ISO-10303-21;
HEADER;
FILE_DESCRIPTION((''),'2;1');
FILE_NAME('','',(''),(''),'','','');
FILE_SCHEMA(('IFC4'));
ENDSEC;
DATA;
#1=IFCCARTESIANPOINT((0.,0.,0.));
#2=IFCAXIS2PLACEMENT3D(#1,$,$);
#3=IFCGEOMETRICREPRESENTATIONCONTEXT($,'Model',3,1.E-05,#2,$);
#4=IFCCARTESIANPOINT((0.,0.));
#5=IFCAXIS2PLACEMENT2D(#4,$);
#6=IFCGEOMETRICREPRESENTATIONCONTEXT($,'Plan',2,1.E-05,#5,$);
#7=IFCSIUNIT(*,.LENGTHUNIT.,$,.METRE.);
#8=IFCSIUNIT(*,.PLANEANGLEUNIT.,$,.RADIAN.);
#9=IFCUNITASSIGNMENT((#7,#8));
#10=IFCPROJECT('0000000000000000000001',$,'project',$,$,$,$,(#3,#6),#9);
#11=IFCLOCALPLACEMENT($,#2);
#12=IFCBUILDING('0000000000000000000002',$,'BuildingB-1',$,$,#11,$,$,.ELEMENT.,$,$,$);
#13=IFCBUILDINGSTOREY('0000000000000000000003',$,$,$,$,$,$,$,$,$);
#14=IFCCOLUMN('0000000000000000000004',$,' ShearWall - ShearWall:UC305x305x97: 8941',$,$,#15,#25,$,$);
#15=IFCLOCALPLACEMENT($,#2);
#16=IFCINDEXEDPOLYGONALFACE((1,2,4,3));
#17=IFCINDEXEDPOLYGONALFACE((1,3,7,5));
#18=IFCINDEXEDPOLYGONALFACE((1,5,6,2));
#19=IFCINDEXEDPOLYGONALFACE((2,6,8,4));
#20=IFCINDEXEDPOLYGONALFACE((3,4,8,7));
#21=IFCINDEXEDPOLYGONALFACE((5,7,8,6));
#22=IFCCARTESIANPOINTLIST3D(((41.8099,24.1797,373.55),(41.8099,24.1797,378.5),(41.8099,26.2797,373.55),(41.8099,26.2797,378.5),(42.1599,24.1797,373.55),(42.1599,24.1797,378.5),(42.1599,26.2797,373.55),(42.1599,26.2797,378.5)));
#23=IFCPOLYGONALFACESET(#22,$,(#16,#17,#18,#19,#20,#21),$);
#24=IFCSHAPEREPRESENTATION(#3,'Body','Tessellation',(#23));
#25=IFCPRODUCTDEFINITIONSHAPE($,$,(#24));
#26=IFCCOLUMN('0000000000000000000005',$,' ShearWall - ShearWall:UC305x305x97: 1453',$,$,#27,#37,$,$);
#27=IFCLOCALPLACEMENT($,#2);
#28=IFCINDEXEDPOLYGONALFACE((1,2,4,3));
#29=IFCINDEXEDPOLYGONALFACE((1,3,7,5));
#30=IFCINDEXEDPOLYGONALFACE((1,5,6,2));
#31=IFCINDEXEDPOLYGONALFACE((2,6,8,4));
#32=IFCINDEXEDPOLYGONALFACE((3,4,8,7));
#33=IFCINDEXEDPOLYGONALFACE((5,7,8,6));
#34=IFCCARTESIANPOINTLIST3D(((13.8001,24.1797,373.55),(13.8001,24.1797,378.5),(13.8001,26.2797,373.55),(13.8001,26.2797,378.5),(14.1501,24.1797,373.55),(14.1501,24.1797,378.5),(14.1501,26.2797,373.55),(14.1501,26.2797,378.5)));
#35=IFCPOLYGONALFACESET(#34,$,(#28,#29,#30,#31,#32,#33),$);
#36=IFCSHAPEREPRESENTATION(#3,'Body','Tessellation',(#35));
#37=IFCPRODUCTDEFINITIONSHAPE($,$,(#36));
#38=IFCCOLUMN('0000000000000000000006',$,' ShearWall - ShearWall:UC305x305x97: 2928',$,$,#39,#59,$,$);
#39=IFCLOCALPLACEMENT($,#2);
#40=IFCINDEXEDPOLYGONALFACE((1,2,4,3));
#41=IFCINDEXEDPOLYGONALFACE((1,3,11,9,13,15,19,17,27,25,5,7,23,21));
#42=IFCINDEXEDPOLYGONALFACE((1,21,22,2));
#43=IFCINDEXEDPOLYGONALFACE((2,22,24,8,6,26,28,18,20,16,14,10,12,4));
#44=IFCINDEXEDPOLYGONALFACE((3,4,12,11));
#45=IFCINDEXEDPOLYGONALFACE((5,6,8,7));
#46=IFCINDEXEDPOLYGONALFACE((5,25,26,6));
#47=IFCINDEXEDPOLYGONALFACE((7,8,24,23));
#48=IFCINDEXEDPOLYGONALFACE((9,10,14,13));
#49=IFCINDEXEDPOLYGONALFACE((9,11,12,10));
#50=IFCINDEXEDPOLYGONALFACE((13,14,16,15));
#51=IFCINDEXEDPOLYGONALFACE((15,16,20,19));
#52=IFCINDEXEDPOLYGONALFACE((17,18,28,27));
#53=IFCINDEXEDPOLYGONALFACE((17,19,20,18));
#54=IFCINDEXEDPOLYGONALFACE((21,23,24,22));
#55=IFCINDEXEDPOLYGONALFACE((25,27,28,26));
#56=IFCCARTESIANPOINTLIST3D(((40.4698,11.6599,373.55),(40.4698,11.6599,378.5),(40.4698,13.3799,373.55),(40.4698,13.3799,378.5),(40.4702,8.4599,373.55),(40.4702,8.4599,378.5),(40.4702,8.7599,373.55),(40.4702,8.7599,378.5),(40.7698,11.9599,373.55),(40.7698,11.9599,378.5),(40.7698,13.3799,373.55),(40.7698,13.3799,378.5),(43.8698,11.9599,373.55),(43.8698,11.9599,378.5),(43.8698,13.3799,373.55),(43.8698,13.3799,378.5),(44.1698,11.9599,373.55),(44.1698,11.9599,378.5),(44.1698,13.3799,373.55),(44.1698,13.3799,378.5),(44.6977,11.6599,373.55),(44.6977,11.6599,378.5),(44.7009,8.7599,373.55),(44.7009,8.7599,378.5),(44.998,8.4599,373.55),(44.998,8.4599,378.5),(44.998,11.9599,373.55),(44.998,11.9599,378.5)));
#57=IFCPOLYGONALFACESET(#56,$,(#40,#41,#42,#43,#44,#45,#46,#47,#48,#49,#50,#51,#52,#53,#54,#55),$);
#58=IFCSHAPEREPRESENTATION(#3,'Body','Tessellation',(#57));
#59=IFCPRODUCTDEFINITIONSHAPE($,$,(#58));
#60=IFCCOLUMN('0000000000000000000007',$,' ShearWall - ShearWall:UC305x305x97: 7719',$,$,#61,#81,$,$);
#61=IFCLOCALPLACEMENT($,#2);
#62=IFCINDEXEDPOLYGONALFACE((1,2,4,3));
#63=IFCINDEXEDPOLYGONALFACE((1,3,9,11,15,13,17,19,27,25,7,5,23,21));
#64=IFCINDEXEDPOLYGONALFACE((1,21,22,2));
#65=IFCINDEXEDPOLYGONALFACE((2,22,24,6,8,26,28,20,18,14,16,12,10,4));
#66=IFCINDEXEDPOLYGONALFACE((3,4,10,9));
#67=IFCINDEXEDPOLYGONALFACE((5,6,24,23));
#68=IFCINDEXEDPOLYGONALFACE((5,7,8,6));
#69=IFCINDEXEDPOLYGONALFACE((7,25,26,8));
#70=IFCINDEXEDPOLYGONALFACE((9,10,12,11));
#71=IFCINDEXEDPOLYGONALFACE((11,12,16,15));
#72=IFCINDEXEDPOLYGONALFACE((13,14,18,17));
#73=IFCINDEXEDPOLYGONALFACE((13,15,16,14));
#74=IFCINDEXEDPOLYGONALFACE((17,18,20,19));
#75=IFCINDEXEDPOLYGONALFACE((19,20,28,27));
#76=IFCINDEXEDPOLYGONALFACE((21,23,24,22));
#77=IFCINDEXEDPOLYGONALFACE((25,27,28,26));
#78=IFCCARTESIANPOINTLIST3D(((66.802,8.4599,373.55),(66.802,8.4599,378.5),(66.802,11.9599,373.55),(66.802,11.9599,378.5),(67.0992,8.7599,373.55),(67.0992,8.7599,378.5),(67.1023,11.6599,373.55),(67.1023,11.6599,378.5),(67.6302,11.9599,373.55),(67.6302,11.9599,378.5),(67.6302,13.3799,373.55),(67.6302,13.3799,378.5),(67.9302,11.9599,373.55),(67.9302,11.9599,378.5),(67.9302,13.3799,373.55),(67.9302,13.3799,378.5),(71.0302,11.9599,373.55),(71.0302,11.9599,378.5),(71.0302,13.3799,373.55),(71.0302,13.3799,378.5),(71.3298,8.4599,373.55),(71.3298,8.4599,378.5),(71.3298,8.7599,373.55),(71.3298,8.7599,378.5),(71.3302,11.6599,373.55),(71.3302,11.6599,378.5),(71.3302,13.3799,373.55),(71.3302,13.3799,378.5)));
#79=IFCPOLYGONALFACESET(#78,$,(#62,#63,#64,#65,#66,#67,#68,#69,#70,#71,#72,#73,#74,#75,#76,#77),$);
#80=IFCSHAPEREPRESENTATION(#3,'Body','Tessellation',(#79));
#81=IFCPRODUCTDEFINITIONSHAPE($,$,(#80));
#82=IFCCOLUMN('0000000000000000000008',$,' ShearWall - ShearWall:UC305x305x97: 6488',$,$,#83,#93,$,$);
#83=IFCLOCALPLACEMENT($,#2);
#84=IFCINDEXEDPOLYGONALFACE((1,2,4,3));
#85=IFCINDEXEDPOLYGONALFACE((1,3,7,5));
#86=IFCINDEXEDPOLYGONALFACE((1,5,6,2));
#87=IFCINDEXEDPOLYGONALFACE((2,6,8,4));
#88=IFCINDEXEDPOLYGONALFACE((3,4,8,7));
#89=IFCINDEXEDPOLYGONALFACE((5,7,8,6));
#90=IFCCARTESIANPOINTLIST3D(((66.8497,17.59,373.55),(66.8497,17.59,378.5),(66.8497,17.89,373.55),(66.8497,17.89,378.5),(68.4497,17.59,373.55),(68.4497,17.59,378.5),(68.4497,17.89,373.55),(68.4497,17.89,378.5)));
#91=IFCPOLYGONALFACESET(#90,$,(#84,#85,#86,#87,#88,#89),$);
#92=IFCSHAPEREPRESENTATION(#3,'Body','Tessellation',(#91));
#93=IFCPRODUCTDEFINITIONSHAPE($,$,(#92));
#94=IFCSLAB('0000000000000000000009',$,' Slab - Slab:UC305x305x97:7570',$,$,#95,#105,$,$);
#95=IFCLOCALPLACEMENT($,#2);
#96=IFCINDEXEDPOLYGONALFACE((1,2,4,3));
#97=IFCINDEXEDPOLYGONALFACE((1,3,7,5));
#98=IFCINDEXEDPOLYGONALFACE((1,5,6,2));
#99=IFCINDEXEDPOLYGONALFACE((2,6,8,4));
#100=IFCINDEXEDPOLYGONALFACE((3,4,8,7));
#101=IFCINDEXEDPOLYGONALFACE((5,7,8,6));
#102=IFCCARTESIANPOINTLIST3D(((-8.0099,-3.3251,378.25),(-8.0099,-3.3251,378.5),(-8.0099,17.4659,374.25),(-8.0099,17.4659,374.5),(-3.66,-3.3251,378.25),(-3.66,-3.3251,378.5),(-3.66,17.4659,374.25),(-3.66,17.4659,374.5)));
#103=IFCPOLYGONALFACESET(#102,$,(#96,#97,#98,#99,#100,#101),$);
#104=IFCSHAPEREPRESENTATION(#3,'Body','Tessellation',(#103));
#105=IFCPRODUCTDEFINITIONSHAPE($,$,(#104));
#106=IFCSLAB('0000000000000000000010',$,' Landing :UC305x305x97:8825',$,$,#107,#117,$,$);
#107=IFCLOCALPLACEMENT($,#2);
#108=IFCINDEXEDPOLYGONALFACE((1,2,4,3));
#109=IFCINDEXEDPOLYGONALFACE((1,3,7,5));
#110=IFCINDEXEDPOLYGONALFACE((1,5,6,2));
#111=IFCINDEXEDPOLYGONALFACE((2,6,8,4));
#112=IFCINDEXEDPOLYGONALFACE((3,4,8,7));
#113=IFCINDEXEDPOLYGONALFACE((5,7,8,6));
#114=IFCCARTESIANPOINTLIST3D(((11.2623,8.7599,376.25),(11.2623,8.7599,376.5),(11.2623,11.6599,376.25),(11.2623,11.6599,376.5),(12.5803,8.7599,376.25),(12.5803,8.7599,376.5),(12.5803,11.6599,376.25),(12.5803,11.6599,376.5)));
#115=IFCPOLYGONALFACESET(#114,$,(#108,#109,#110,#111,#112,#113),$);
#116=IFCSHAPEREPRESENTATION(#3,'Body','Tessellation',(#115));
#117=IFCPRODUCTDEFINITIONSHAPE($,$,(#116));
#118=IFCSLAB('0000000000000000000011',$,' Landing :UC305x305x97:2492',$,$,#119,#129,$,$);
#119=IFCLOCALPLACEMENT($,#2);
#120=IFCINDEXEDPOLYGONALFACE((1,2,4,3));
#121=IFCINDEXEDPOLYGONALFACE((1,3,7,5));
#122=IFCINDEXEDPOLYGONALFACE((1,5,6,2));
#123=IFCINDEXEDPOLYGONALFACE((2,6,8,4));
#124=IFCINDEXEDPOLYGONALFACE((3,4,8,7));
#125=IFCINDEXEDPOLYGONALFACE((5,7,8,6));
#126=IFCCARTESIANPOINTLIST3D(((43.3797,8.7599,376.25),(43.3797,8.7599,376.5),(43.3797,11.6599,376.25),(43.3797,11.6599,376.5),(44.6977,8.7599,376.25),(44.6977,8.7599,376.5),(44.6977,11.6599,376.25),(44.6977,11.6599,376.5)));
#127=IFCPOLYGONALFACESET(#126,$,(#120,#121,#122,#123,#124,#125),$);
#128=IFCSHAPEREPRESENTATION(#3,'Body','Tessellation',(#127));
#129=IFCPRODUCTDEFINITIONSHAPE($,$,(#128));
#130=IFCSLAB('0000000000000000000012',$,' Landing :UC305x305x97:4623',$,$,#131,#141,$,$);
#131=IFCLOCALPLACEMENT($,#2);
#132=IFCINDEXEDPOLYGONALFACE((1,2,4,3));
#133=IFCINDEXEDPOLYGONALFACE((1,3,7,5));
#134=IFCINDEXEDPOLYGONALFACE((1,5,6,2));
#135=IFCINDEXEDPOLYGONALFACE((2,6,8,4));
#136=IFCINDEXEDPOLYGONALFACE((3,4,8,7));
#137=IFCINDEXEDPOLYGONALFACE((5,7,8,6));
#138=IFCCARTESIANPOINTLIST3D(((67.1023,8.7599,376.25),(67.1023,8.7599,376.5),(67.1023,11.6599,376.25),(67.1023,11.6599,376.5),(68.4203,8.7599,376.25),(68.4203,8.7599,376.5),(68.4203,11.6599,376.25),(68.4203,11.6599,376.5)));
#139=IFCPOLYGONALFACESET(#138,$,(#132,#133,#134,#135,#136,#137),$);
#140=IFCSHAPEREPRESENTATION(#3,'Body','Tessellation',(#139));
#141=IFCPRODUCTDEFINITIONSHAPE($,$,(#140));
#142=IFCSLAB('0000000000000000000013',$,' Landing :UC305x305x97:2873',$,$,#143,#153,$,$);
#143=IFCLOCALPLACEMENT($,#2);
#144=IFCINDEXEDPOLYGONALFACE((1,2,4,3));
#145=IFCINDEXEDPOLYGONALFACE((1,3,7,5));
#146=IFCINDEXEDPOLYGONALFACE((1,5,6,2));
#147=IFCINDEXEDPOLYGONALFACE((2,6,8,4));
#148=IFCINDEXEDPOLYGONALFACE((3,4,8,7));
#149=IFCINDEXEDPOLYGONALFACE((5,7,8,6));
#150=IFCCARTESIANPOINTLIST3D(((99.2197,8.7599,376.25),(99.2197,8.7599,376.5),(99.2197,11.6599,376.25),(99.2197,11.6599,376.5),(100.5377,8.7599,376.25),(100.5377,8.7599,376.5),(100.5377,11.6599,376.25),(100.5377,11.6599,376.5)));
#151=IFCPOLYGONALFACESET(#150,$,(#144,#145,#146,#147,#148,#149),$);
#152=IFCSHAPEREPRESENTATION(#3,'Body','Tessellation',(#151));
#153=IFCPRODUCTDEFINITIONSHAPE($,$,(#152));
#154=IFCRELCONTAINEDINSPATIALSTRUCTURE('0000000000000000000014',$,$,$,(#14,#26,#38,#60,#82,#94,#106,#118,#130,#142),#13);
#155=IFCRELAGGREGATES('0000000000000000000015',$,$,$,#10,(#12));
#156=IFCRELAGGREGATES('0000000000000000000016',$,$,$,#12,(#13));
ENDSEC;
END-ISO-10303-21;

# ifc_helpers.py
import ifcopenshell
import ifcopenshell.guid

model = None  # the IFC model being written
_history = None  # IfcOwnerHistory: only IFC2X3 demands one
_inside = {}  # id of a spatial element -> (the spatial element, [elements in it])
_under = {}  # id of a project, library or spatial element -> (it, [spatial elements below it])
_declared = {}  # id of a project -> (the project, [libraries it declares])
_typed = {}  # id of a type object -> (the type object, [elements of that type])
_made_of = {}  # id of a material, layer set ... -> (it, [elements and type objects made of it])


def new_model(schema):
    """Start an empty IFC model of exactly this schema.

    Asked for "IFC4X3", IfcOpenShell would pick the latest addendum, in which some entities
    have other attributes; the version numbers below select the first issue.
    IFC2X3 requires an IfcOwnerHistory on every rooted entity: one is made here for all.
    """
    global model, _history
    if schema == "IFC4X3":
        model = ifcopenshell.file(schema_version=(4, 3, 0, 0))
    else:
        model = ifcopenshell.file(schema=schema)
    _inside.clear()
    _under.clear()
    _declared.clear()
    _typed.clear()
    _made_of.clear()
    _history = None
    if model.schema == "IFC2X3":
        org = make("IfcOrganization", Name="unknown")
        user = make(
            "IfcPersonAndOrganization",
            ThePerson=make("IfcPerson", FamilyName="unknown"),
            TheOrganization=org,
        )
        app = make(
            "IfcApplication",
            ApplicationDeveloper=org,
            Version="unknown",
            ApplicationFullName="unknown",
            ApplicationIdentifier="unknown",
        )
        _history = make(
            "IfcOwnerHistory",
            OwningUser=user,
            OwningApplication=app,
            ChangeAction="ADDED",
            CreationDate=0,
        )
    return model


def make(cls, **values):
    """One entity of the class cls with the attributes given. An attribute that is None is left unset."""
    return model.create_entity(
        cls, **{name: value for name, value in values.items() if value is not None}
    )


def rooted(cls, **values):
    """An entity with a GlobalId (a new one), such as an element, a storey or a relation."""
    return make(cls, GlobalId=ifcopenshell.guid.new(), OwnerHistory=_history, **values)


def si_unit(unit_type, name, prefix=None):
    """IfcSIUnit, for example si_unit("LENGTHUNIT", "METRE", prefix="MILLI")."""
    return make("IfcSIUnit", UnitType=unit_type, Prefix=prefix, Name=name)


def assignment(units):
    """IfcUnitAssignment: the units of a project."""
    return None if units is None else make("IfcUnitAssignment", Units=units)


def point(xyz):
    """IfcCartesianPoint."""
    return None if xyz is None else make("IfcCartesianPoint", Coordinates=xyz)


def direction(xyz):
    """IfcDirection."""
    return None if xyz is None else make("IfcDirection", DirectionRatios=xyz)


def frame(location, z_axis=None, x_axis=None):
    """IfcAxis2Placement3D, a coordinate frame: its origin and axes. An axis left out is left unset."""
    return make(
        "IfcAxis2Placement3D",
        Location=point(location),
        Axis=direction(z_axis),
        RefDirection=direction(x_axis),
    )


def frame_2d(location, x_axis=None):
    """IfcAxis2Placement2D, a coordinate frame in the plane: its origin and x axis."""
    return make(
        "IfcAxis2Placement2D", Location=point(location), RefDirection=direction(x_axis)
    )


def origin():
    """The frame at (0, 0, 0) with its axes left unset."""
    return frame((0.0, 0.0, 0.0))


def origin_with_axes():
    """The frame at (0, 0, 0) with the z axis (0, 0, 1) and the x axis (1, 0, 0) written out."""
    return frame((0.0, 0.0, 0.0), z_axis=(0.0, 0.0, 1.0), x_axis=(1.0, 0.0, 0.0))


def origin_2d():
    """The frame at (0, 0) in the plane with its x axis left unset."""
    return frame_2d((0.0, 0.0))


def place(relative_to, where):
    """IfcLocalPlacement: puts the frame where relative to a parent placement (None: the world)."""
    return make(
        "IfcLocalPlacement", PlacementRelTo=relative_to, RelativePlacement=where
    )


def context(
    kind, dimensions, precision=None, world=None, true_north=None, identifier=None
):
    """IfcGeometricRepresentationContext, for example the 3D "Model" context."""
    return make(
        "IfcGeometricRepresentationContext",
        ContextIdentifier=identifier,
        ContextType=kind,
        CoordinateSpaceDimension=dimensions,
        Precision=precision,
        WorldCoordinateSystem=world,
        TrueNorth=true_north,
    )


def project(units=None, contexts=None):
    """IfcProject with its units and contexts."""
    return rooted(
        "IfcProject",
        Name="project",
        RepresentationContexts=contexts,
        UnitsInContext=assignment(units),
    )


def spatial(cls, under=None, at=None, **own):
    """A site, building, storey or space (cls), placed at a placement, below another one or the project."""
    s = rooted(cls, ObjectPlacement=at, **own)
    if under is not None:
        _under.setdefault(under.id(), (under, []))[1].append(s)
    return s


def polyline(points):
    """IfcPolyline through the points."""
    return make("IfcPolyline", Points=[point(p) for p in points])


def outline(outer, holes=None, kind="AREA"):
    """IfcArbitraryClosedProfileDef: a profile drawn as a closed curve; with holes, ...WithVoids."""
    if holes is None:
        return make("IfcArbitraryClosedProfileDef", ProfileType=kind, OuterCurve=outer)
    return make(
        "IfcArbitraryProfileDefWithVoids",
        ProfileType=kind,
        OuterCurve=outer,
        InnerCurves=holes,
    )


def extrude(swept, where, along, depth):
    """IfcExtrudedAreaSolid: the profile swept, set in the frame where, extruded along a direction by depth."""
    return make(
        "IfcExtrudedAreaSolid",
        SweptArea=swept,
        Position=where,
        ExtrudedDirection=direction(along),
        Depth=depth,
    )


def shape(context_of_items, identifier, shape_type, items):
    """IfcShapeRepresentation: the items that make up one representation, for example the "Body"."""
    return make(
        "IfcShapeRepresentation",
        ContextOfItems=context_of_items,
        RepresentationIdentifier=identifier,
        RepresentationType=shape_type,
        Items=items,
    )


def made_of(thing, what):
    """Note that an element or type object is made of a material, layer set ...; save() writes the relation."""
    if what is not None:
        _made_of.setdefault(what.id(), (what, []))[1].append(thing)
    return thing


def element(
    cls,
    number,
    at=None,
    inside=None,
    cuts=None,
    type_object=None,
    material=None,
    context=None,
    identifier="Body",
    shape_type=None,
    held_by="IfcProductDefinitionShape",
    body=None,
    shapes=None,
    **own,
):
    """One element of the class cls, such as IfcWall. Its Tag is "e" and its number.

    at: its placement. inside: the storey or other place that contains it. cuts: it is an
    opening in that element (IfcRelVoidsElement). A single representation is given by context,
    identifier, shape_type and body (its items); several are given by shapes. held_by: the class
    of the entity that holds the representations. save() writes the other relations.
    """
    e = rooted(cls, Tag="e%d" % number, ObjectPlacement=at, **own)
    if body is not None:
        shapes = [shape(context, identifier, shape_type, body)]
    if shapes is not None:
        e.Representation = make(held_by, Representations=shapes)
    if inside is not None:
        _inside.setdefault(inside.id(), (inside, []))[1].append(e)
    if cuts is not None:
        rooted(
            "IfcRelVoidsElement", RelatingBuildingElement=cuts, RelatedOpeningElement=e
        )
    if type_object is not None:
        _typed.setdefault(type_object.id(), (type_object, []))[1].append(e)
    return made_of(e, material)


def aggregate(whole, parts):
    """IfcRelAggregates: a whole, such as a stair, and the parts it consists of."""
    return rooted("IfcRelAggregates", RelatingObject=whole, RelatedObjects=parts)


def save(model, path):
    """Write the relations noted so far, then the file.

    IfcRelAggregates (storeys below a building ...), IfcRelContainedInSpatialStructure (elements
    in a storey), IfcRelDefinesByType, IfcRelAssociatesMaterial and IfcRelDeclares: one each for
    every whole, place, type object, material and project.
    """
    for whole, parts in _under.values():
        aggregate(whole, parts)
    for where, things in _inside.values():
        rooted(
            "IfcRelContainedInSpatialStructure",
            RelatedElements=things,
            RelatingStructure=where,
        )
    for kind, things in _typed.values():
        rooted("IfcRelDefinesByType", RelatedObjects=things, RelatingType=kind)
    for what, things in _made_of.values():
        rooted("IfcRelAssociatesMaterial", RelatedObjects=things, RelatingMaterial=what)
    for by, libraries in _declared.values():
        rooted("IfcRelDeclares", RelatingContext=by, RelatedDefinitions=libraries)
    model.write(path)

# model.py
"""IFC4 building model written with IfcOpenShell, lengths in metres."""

from ifc_helpers import new_model, si_unit, origin, origin_with_axes, origin_2d, place, context, project, spatial, polyline, outline, extrude, element, save


model = new_model("IFC4")

# Units and contexts
model_context = context("Model", 3, precision=1e-05, world=origin())
plan_context = context("Plan", 2, precision=1e-05, world=origin_2d())
ifc_project = project(units=[si_unit("LENGTHUNIT", "METRE"), si_unit("PLANEANGLEUNIT", "RADIAN")], contexts=[model_context, plan_context])

# Building, storey
building_placement = place(None, origin())
building = spatial("IfcBuilding", under=ifc_project, at=building_placement, Name="BuildingB-1", CompositionType="ELEMENT")
storey = spatial("IfcBuildingStorey", under=building)

# Columns
column_1_placement = place(None, origin_with_axes())
element("IfcColumn", 1, at=column_1_placement, inside=storey, Name=" ShearWall - ShearWall:UC305x305x97: 8941", context=model_context, shape_type="SweptSolid", body=[
    extrude(outline(polyline([(41.8099, 26.2797, 378.5), (42.1599, 26.2797, 378.5), (42.1599, 24.1797, 378.5), (41.8099, 24.1797, 378.5), (41.8099, 26.2797, 378.5)])), None, (0.0, 0.0, -1.0), 4.95),
])
column_2_placement = place(None, origin_with_axes())
element("IfcColumn", 2, at=column_2_placement, inside=storey, Name=" ShearWall - ShearWall:UC305x305x97: 1453", context=model_context, shape_type="SweptSolid", body=[
    extrude(outline(polyline([(14.1501, 26.2797, 378.5), (13.8001, 26.2797, 378.5), (13.8001, 24.1797, 378.5), (14.1501, 24.1797, 378.5), (14.1501, 26.2797, 378.5)])), None, (0.0, 0.0, -1.0), 4.95),
])
column_3_placement = place(None, origin_with_axes())
element("IfcColumn", 3, at=column_3_placement, inside=storey, Name=" ShearWall - ShearWall:UC305x305x97: 2928", context=model_context, shape_type="SweptSolid", body=[
    extrude(outline(polyline([(44.998, 8.4599, 378.5), (40.4702, 8.4599, 378.5), (40.4702, 8.7599, 378.5), (44.7009, 8.7599, 378.5), (44.6977, 11.6599, 378.5), (40.4698, 11.6599, 378.5), (40.4698, 13.3799, 378.5), (40.7698, 13.3799, 378.5), (40.7698, 11.9599, 378.5), (43.8698, 11.9599, 378.5), (43.8698, 13.3799, 378.5), (44.1698, 13.3799, 378.5), (44.1698, 11.9599, 378.5), (44.998, 11.9599, 378.5), (44.998, 8.4599, 378.5)])), None, (0.0, 0.0, -1.0), 4.95),
])
column_4_placement = place(None, origin_with_axes())
element("IfcColumn", 4, at=column_4_placement, inside=storey, Name=" ShearWall - ShearWall:UC305x305x97: 7719", context=model_context, shape_type="SweptSolid", body=[
    extrude(outline(polyline([(66.802, 8.4599, 378.5), (71.3298, 8.4599, 378.5), (71.3298, 8.7599, 378.5), (67.0992, 8.7599, 378.5), (67.1023, 11.6599, 378.5), (71.3302, 11.6599, 378.5), (71.3302, 13.3799, 378.5), (71.0302, 13.3799, 378.5), (71.0302, 11.9599, 378.5), (67.9302, 11.9599, 378.5), (67.9302, 13.3799, 378.5), (67.6302, 13.3799, 378.5), (67.6302, 11.9599, 378.5), (66.802, 11.9599, 378.5), (66.802, 8.4599, 378.5)])), None, (0.0, 0.0, -1.0), 4.95),
])
column_5_placement = place(None, origin_with_axes())
element("IfcColumn", 5, at=column_5_placement, inside=storey, Name=" ShearWall - ShearWall:UC305x305x97: 6488", context=model_context, shape_type="SweptSolid", body=[
    extrude(outline(polyline([(66.8497, 17.59, 378.5), (66.8497, 17.89, 378.5), (68.4497, 17.89, 378.5), (68.4497, 17.59, 378.5), (66.8497, 17.59, 378.5)])), None, (0.0, 0.0, -1.0), 4.95),
])

# Slabs
element("IfcSlab", 6, inside=storey, Name=" Slab - Slab:UC305x305x97:7570", context=model_context, shape_type="SweptSolid", body=[
    extrude(outline(polyline([(-3.66, -3.3251, 378.5), (-3.66, 17.4659, 374.5), (-8.0099, 17.4659, 374.5), (-8.0099, -3.3251, 378.5), (-3.66, -3.3251, 378.5)])), None, (0.0, 0.0, -1.0), 0.25),
])
element("IfcSlab", 7, inside=storey, Name=" Landing :UC305x305x97:8825", context=model_context, shape_type="SweptSolid", body=[
    extrude(outline(polyline([(11.2623, 11.6599, 376.5), (11.2623, 8.7599, 376.5), (12.5803, 8.7599, 376.5), (12.5803, 11.6599, 376.5), (11.2623, 11.6599, 376.5)])), None, (0.0, 0.0, -1.0), 0.25),
])
element("IfcSlab", 8, inside=storey, Name=" Landing :UC305x305x97:2492", context=model_context, shape_type="SweptSolid", body=[
    extrude(outline(polyline([(44.6977, 11.6599, 376.5), (44.6977, 8.7599, 376.5), (43.3797, 8.7599, 376.5), (43.3797, 11.6599, 376.5), (44.6977, 11.6599, 376.5)])), None, (0.0, 0.0, -1.0), 0.25),
])
element("IfcSlab", 9, inside=storey, Name=" Landing :UC305x305x97:4623", context=model_context, shape_type="SweptSolid", body=[
    extrude(outline(polyline([(67.1023, 11.6599, 376.5), (67.1023, 8.7599, 376.5), (68.4203, 8.7599, 376.5), (68.4203, 11.6599, 376.5), (67.1023, 11.6599, 376.5)])), None, (0.0, 0.0, -1.0), 0.25),
])
element("IfcSlab", 10, inside=storey, Name=" Landing :UC305x305x97:2873", context=model_context, shape_type="SweptSolid", body=[
    extrude(outline(polyline([(100.5377, 11.6599, 376.5), (100.5377, 8.7599, 376.5), (99.2197, 8.7599, 376.5), (99.2197, 11.6599, 376.5), (100.5377, 11.6599, 376.5)])), None, (0.0, 0.0, -1.0), 0.25),
])

save(model, "model.ifc")
